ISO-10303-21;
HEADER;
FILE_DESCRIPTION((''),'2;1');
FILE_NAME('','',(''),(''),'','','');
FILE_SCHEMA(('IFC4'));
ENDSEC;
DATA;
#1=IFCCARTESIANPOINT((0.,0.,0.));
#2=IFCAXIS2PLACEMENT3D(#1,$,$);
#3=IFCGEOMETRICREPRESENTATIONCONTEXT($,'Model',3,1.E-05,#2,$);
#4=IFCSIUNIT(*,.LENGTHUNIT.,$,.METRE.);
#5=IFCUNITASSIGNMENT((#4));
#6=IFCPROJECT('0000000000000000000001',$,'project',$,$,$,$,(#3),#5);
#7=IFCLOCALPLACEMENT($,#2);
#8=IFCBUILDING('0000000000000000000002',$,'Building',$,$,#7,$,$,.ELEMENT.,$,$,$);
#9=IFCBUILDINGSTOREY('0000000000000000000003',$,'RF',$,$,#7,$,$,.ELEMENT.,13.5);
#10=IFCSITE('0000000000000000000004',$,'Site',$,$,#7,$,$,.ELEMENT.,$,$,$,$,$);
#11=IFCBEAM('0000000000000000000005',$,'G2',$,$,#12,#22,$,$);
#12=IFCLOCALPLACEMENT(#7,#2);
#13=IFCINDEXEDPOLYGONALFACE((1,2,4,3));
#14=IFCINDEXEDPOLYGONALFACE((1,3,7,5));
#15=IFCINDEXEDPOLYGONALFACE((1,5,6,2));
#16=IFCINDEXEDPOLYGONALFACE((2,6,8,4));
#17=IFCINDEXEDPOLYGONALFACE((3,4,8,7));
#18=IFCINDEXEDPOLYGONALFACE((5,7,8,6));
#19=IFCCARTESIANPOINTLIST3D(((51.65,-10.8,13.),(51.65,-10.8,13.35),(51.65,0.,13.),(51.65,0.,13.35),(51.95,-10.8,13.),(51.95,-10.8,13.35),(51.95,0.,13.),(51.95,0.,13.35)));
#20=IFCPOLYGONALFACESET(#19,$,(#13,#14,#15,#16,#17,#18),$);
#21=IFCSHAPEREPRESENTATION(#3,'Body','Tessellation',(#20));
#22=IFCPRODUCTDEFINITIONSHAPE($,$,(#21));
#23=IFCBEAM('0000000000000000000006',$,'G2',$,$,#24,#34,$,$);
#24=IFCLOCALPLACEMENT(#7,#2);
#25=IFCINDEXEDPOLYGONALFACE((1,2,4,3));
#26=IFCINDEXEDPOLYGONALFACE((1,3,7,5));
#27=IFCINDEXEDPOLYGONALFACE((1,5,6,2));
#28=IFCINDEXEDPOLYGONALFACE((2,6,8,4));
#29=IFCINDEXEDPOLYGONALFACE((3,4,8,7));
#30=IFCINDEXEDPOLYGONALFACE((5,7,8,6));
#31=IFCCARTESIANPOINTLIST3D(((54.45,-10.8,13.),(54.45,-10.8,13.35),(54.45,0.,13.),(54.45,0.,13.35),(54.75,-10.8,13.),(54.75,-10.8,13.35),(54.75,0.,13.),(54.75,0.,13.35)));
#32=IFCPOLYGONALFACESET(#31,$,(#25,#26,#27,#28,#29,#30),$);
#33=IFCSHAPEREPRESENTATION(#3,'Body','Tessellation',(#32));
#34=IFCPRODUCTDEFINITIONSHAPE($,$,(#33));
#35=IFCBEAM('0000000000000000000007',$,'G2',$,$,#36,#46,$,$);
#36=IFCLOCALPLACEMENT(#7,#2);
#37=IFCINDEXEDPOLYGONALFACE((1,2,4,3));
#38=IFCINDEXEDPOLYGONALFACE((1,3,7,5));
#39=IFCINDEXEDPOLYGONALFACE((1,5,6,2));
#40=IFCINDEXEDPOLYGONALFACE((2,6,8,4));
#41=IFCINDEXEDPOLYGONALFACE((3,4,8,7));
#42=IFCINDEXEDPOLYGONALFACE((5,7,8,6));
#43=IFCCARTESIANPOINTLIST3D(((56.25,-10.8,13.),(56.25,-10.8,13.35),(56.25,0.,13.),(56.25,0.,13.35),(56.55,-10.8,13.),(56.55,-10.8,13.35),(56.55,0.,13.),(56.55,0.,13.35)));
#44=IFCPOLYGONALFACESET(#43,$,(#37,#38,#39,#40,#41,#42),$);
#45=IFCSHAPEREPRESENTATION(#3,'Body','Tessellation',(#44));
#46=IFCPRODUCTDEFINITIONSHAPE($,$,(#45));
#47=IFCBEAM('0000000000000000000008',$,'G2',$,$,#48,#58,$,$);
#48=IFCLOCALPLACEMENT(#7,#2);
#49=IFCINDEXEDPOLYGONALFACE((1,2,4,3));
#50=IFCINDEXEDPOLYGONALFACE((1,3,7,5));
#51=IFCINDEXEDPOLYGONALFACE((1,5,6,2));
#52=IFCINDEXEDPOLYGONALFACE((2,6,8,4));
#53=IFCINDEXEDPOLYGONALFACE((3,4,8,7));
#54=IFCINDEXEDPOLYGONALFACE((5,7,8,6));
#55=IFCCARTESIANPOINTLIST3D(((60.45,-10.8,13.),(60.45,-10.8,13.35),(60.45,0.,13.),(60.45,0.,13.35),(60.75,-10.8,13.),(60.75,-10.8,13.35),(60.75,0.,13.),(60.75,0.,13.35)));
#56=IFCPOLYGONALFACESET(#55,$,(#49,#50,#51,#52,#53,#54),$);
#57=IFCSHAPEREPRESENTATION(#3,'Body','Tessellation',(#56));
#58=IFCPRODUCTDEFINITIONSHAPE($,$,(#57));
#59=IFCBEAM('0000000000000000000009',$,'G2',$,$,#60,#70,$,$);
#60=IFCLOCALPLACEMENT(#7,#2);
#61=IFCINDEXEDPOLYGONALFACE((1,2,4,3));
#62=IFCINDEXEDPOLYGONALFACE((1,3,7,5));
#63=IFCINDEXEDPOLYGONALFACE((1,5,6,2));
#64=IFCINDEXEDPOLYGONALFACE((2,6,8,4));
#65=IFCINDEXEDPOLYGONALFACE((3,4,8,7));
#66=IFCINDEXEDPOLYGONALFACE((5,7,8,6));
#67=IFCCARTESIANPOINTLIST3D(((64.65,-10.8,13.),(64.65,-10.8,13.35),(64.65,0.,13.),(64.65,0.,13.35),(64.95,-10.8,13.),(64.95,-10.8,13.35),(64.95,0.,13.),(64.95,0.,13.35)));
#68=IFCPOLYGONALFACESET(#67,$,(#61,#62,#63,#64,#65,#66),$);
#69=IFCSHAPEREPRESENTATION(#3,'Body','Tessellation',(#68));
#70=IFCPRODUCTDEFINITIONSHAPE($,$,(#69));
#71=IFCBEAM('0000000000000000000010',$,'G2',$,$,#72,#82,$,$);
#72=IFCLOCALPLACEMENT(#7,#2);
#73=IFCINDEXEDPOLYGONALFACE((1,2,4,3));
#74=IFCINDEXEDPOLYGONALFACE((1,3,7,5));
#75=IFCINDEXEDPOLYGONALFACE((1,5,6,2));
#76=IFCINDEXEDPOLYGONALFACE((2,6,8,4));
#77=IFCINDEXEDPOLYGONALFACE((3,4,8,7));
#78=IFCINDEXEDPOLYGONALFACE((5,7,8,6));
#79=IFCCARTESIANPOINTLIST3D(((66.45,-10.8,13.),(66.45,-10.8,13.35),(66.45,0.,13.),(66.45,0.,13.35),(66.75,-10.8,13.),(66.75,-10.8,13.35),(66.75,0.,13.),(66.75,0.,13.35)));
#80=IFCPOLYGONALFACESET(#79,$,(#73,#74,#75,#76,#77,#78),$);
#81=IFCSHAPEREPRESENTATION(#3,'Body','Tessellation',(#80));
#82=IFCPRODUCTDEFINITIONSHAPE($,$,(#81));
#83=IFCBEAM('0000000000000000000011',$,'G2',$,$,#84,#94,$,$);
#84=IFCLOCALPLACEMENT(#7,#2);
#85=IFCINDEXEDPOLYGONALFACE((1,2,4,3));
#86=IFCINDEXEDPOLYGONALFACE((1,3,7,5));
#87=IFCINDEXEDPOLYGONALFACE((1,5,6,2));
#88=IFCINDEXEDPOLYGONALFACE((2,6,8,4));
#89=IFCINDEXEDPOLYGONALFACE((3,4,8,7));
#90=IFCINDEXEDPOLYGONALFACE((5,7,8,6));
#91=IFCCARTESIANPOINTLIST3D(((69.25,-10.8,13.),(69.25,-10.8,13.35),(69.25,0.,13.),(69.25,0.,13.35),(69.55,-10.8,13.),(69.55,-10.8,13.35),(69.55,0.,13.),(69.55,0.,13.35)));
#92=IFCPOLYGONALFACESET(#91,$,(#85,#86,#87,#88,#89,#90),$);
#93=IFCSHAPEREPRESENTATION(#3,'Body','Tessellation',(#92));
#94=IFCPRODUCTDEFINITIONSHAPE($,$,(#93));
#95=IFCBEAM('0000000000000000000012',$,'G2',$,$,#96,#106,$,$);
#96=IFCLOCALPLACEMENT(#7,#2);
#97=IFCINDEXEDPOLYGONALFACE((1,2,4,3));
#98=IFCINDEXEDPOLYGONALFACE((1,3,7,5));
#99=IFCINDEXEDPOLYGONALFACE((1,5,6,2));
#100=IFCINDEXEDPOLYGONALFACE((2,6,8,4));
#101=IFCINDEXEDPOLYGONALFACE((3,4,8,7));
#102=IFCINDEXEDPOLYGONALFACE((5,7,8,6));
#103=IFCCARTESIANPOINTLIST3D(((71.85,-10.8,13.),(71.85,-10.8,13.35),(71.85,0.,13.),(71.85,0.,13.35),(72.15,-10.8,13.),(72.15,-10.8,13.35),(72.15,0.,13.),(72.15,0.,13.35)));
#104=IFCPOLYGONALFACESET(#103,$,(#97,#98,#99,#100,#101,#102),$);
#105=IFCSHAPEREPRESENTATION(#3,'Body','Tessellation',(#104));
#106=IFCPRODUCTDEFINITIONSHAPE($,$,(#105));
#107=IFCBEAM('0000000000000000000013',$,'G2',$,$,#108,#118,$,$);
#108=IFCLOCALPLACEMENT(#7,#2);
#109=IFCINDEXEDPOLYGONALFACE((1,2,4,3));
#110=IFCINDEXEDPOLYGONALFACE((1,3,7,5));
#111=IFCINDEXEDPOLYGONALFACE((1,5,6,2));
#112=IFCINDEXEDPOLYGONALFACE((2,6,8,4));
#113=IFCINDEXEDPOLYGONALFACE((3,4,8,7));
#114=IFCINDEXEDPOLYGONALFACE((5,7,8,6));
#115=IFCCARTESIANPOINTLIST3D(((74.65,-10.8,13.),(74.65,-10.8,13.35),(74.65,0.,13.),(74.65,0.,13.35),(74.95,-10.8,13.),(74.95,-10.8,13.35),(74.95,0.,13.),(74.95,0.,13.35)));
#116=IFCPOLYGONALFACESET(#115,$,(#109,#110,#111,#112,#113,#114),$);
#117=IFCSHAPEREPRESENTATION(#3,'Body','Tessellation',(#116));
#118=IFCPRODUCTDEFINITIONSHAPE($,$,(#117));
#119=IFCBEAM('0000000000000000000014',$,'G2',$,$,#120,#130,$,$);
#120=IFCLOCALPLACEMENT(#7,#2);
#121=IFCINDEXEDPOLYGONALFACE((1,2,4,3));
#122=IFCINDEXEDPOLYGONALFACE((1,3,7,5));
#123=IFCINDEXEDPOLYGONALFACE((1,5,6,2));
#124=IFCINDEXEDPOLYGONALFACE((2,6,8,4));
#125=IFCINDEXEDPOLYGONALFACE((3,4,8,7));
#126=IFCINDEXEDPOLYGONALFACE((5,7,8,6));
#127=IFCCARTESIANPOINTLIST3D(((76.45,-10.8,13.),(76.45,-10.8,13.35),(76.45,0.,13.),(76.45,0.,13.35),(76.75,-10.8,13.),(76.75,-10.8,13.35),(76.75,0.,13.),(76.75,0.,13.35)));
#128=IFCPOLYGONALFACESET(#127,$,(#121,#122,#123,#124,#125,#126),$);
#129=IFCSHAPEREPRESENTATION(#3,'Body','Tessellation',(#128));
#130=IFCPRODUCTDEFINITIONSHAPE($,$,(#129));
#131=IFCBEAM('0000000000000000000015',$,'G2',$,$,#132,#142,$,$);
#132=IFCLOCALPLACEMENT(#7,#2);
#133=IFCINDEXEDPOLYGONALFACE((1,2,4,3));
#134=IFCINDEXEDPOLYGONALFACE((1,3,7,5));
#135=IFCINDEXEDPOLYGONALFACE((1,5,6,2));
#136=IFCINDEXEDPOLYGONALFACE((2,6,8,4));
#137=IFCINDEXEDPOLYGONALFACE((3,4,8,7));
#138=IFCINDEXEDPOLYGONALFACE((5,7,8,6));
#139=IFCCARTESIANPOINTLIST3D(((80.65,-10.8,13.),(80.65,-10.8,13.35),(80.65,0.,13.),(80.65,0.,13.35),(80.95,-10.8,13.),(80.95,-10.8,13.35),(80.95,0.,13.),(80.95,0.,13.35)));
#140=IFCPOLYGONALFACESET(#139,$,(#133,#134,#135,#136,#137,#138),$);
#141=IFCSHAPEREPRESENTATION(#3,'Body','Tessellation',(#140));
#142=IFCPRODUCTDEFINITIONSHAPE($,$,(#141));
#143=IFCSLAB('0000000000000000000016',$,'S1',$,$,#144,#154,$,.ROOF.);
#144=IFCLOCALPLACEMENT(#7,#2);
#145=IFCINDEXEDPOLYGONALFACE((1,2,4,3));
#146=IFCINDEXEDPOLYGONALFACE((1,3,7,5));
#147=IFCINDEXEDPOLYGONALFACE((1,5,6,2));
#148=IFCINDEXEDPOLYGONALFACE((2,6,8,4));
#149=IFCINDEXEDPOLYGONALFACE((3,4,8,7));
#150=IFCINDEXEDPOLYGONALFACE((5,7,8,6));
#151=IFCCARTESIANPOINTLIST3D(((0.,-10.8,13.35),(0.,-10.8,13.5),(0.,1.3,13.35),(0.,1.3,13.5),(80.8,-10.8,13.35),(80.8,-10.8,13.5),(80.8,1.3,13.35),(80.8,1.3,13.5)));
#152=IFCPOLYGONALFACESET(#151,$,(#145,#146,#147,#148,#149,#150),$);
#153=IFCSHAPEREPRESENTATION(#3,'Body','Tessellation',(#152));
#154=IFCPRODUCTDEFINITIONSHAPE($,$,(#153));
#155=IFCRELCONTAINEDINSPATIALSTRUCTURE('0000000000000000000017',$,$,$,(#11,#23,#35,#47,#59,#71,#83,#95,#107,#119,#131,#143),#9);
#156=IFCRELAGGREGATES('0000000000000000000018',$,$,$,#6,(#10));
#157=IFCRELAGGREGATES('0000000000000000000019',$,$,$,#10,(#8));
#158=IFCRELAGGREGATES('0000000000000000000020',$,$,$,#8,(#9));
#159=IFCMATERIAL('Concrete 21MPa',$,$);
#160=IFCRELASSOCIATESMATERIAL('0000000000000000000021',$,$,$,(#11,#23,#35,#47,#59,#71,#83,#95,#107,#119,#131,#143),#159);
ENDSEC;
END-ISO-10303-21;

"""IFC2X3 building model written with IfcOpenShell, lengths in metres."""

from ifc_helpers import new_model, si_unit, frame, origin, origin_2d, place, context, project, spatial, rectangle, extrude, material, element, save


model = new_model("IFC2X3")

# Units and contexts
model_context = context("Model", 3, precision=1e-05, world=origin())
ifc_project = project(units=[si_unit("LENGTHUNIT", "METRE")], contexts=[model_context])

# Site, building, storey
placement = place(None, origin())
site = spatial("IfcSite", under=ifc_project, at=placement, Name="Site", CompositionType="ELEMENT")
building = spatial("IfcBuilding", under=site, at=placement, Name="Building", CompositionType="ELEMENT")
storey = spatial("IfcBuildingStorey", under=building, at=placement, Name="RF", CompositionType="ELEMENT", Elevation=13.5)

# Beams
ifc_material = material(Name="Concrete 21MPa")
for number, where, name in (
    (1, (51.8, -5.4, 13.0), "G2"),
    (2, (54.6, -5.4, 13.0), "G2"),
    (3, (56.4, -5.4, 13.0), "G2"),
    (4, (60.6, -5.4, 13.0), "G2"),
    (5, (64.8, -5.4, 13.0), "G2"),
    (6, (66.6, -5.4, 13.0), "G2"),
    (7, (69.4, -5.4, 13.0), "G2"),
    (8, (72.0, -5.4, 13.0), "G2"),
    (9, (74.8, -5.4, 13.0), "G2"),
    (10, (76.6, -5.4, 13.0), "G2"),
    (11, (80.8, -5.4, 13.0), "G2"),
):
    element("IfcBeam", number, at=place(None, frame(where)), inside=storey, material=ifc_material, Name=name, context=model_context, shape_type="SweptSolid", body=[
        extrude(rectangle(XDim=0.3, YDim=10.8, at=origin_2d()), origin(), (0.0, 0.0, 1.0), 0.35),
    ])

# Slab
slab_placement = place(None, frame((40.4, -4.75, 13.35)))
element("IfcSlab", 12, at=slab_placement, inside=storey, material=ifc_material, Name="S1", PredefinedType="ROOF", context=model_context, shape_type="SweptSolid", body=[
    extrude(rectangle(XDim=80.8, YDim=12.1, at=origin_2d()), origin(), (0.0, 0.0, 1.0), 0.15),
])

save(model, "model.ifc")
